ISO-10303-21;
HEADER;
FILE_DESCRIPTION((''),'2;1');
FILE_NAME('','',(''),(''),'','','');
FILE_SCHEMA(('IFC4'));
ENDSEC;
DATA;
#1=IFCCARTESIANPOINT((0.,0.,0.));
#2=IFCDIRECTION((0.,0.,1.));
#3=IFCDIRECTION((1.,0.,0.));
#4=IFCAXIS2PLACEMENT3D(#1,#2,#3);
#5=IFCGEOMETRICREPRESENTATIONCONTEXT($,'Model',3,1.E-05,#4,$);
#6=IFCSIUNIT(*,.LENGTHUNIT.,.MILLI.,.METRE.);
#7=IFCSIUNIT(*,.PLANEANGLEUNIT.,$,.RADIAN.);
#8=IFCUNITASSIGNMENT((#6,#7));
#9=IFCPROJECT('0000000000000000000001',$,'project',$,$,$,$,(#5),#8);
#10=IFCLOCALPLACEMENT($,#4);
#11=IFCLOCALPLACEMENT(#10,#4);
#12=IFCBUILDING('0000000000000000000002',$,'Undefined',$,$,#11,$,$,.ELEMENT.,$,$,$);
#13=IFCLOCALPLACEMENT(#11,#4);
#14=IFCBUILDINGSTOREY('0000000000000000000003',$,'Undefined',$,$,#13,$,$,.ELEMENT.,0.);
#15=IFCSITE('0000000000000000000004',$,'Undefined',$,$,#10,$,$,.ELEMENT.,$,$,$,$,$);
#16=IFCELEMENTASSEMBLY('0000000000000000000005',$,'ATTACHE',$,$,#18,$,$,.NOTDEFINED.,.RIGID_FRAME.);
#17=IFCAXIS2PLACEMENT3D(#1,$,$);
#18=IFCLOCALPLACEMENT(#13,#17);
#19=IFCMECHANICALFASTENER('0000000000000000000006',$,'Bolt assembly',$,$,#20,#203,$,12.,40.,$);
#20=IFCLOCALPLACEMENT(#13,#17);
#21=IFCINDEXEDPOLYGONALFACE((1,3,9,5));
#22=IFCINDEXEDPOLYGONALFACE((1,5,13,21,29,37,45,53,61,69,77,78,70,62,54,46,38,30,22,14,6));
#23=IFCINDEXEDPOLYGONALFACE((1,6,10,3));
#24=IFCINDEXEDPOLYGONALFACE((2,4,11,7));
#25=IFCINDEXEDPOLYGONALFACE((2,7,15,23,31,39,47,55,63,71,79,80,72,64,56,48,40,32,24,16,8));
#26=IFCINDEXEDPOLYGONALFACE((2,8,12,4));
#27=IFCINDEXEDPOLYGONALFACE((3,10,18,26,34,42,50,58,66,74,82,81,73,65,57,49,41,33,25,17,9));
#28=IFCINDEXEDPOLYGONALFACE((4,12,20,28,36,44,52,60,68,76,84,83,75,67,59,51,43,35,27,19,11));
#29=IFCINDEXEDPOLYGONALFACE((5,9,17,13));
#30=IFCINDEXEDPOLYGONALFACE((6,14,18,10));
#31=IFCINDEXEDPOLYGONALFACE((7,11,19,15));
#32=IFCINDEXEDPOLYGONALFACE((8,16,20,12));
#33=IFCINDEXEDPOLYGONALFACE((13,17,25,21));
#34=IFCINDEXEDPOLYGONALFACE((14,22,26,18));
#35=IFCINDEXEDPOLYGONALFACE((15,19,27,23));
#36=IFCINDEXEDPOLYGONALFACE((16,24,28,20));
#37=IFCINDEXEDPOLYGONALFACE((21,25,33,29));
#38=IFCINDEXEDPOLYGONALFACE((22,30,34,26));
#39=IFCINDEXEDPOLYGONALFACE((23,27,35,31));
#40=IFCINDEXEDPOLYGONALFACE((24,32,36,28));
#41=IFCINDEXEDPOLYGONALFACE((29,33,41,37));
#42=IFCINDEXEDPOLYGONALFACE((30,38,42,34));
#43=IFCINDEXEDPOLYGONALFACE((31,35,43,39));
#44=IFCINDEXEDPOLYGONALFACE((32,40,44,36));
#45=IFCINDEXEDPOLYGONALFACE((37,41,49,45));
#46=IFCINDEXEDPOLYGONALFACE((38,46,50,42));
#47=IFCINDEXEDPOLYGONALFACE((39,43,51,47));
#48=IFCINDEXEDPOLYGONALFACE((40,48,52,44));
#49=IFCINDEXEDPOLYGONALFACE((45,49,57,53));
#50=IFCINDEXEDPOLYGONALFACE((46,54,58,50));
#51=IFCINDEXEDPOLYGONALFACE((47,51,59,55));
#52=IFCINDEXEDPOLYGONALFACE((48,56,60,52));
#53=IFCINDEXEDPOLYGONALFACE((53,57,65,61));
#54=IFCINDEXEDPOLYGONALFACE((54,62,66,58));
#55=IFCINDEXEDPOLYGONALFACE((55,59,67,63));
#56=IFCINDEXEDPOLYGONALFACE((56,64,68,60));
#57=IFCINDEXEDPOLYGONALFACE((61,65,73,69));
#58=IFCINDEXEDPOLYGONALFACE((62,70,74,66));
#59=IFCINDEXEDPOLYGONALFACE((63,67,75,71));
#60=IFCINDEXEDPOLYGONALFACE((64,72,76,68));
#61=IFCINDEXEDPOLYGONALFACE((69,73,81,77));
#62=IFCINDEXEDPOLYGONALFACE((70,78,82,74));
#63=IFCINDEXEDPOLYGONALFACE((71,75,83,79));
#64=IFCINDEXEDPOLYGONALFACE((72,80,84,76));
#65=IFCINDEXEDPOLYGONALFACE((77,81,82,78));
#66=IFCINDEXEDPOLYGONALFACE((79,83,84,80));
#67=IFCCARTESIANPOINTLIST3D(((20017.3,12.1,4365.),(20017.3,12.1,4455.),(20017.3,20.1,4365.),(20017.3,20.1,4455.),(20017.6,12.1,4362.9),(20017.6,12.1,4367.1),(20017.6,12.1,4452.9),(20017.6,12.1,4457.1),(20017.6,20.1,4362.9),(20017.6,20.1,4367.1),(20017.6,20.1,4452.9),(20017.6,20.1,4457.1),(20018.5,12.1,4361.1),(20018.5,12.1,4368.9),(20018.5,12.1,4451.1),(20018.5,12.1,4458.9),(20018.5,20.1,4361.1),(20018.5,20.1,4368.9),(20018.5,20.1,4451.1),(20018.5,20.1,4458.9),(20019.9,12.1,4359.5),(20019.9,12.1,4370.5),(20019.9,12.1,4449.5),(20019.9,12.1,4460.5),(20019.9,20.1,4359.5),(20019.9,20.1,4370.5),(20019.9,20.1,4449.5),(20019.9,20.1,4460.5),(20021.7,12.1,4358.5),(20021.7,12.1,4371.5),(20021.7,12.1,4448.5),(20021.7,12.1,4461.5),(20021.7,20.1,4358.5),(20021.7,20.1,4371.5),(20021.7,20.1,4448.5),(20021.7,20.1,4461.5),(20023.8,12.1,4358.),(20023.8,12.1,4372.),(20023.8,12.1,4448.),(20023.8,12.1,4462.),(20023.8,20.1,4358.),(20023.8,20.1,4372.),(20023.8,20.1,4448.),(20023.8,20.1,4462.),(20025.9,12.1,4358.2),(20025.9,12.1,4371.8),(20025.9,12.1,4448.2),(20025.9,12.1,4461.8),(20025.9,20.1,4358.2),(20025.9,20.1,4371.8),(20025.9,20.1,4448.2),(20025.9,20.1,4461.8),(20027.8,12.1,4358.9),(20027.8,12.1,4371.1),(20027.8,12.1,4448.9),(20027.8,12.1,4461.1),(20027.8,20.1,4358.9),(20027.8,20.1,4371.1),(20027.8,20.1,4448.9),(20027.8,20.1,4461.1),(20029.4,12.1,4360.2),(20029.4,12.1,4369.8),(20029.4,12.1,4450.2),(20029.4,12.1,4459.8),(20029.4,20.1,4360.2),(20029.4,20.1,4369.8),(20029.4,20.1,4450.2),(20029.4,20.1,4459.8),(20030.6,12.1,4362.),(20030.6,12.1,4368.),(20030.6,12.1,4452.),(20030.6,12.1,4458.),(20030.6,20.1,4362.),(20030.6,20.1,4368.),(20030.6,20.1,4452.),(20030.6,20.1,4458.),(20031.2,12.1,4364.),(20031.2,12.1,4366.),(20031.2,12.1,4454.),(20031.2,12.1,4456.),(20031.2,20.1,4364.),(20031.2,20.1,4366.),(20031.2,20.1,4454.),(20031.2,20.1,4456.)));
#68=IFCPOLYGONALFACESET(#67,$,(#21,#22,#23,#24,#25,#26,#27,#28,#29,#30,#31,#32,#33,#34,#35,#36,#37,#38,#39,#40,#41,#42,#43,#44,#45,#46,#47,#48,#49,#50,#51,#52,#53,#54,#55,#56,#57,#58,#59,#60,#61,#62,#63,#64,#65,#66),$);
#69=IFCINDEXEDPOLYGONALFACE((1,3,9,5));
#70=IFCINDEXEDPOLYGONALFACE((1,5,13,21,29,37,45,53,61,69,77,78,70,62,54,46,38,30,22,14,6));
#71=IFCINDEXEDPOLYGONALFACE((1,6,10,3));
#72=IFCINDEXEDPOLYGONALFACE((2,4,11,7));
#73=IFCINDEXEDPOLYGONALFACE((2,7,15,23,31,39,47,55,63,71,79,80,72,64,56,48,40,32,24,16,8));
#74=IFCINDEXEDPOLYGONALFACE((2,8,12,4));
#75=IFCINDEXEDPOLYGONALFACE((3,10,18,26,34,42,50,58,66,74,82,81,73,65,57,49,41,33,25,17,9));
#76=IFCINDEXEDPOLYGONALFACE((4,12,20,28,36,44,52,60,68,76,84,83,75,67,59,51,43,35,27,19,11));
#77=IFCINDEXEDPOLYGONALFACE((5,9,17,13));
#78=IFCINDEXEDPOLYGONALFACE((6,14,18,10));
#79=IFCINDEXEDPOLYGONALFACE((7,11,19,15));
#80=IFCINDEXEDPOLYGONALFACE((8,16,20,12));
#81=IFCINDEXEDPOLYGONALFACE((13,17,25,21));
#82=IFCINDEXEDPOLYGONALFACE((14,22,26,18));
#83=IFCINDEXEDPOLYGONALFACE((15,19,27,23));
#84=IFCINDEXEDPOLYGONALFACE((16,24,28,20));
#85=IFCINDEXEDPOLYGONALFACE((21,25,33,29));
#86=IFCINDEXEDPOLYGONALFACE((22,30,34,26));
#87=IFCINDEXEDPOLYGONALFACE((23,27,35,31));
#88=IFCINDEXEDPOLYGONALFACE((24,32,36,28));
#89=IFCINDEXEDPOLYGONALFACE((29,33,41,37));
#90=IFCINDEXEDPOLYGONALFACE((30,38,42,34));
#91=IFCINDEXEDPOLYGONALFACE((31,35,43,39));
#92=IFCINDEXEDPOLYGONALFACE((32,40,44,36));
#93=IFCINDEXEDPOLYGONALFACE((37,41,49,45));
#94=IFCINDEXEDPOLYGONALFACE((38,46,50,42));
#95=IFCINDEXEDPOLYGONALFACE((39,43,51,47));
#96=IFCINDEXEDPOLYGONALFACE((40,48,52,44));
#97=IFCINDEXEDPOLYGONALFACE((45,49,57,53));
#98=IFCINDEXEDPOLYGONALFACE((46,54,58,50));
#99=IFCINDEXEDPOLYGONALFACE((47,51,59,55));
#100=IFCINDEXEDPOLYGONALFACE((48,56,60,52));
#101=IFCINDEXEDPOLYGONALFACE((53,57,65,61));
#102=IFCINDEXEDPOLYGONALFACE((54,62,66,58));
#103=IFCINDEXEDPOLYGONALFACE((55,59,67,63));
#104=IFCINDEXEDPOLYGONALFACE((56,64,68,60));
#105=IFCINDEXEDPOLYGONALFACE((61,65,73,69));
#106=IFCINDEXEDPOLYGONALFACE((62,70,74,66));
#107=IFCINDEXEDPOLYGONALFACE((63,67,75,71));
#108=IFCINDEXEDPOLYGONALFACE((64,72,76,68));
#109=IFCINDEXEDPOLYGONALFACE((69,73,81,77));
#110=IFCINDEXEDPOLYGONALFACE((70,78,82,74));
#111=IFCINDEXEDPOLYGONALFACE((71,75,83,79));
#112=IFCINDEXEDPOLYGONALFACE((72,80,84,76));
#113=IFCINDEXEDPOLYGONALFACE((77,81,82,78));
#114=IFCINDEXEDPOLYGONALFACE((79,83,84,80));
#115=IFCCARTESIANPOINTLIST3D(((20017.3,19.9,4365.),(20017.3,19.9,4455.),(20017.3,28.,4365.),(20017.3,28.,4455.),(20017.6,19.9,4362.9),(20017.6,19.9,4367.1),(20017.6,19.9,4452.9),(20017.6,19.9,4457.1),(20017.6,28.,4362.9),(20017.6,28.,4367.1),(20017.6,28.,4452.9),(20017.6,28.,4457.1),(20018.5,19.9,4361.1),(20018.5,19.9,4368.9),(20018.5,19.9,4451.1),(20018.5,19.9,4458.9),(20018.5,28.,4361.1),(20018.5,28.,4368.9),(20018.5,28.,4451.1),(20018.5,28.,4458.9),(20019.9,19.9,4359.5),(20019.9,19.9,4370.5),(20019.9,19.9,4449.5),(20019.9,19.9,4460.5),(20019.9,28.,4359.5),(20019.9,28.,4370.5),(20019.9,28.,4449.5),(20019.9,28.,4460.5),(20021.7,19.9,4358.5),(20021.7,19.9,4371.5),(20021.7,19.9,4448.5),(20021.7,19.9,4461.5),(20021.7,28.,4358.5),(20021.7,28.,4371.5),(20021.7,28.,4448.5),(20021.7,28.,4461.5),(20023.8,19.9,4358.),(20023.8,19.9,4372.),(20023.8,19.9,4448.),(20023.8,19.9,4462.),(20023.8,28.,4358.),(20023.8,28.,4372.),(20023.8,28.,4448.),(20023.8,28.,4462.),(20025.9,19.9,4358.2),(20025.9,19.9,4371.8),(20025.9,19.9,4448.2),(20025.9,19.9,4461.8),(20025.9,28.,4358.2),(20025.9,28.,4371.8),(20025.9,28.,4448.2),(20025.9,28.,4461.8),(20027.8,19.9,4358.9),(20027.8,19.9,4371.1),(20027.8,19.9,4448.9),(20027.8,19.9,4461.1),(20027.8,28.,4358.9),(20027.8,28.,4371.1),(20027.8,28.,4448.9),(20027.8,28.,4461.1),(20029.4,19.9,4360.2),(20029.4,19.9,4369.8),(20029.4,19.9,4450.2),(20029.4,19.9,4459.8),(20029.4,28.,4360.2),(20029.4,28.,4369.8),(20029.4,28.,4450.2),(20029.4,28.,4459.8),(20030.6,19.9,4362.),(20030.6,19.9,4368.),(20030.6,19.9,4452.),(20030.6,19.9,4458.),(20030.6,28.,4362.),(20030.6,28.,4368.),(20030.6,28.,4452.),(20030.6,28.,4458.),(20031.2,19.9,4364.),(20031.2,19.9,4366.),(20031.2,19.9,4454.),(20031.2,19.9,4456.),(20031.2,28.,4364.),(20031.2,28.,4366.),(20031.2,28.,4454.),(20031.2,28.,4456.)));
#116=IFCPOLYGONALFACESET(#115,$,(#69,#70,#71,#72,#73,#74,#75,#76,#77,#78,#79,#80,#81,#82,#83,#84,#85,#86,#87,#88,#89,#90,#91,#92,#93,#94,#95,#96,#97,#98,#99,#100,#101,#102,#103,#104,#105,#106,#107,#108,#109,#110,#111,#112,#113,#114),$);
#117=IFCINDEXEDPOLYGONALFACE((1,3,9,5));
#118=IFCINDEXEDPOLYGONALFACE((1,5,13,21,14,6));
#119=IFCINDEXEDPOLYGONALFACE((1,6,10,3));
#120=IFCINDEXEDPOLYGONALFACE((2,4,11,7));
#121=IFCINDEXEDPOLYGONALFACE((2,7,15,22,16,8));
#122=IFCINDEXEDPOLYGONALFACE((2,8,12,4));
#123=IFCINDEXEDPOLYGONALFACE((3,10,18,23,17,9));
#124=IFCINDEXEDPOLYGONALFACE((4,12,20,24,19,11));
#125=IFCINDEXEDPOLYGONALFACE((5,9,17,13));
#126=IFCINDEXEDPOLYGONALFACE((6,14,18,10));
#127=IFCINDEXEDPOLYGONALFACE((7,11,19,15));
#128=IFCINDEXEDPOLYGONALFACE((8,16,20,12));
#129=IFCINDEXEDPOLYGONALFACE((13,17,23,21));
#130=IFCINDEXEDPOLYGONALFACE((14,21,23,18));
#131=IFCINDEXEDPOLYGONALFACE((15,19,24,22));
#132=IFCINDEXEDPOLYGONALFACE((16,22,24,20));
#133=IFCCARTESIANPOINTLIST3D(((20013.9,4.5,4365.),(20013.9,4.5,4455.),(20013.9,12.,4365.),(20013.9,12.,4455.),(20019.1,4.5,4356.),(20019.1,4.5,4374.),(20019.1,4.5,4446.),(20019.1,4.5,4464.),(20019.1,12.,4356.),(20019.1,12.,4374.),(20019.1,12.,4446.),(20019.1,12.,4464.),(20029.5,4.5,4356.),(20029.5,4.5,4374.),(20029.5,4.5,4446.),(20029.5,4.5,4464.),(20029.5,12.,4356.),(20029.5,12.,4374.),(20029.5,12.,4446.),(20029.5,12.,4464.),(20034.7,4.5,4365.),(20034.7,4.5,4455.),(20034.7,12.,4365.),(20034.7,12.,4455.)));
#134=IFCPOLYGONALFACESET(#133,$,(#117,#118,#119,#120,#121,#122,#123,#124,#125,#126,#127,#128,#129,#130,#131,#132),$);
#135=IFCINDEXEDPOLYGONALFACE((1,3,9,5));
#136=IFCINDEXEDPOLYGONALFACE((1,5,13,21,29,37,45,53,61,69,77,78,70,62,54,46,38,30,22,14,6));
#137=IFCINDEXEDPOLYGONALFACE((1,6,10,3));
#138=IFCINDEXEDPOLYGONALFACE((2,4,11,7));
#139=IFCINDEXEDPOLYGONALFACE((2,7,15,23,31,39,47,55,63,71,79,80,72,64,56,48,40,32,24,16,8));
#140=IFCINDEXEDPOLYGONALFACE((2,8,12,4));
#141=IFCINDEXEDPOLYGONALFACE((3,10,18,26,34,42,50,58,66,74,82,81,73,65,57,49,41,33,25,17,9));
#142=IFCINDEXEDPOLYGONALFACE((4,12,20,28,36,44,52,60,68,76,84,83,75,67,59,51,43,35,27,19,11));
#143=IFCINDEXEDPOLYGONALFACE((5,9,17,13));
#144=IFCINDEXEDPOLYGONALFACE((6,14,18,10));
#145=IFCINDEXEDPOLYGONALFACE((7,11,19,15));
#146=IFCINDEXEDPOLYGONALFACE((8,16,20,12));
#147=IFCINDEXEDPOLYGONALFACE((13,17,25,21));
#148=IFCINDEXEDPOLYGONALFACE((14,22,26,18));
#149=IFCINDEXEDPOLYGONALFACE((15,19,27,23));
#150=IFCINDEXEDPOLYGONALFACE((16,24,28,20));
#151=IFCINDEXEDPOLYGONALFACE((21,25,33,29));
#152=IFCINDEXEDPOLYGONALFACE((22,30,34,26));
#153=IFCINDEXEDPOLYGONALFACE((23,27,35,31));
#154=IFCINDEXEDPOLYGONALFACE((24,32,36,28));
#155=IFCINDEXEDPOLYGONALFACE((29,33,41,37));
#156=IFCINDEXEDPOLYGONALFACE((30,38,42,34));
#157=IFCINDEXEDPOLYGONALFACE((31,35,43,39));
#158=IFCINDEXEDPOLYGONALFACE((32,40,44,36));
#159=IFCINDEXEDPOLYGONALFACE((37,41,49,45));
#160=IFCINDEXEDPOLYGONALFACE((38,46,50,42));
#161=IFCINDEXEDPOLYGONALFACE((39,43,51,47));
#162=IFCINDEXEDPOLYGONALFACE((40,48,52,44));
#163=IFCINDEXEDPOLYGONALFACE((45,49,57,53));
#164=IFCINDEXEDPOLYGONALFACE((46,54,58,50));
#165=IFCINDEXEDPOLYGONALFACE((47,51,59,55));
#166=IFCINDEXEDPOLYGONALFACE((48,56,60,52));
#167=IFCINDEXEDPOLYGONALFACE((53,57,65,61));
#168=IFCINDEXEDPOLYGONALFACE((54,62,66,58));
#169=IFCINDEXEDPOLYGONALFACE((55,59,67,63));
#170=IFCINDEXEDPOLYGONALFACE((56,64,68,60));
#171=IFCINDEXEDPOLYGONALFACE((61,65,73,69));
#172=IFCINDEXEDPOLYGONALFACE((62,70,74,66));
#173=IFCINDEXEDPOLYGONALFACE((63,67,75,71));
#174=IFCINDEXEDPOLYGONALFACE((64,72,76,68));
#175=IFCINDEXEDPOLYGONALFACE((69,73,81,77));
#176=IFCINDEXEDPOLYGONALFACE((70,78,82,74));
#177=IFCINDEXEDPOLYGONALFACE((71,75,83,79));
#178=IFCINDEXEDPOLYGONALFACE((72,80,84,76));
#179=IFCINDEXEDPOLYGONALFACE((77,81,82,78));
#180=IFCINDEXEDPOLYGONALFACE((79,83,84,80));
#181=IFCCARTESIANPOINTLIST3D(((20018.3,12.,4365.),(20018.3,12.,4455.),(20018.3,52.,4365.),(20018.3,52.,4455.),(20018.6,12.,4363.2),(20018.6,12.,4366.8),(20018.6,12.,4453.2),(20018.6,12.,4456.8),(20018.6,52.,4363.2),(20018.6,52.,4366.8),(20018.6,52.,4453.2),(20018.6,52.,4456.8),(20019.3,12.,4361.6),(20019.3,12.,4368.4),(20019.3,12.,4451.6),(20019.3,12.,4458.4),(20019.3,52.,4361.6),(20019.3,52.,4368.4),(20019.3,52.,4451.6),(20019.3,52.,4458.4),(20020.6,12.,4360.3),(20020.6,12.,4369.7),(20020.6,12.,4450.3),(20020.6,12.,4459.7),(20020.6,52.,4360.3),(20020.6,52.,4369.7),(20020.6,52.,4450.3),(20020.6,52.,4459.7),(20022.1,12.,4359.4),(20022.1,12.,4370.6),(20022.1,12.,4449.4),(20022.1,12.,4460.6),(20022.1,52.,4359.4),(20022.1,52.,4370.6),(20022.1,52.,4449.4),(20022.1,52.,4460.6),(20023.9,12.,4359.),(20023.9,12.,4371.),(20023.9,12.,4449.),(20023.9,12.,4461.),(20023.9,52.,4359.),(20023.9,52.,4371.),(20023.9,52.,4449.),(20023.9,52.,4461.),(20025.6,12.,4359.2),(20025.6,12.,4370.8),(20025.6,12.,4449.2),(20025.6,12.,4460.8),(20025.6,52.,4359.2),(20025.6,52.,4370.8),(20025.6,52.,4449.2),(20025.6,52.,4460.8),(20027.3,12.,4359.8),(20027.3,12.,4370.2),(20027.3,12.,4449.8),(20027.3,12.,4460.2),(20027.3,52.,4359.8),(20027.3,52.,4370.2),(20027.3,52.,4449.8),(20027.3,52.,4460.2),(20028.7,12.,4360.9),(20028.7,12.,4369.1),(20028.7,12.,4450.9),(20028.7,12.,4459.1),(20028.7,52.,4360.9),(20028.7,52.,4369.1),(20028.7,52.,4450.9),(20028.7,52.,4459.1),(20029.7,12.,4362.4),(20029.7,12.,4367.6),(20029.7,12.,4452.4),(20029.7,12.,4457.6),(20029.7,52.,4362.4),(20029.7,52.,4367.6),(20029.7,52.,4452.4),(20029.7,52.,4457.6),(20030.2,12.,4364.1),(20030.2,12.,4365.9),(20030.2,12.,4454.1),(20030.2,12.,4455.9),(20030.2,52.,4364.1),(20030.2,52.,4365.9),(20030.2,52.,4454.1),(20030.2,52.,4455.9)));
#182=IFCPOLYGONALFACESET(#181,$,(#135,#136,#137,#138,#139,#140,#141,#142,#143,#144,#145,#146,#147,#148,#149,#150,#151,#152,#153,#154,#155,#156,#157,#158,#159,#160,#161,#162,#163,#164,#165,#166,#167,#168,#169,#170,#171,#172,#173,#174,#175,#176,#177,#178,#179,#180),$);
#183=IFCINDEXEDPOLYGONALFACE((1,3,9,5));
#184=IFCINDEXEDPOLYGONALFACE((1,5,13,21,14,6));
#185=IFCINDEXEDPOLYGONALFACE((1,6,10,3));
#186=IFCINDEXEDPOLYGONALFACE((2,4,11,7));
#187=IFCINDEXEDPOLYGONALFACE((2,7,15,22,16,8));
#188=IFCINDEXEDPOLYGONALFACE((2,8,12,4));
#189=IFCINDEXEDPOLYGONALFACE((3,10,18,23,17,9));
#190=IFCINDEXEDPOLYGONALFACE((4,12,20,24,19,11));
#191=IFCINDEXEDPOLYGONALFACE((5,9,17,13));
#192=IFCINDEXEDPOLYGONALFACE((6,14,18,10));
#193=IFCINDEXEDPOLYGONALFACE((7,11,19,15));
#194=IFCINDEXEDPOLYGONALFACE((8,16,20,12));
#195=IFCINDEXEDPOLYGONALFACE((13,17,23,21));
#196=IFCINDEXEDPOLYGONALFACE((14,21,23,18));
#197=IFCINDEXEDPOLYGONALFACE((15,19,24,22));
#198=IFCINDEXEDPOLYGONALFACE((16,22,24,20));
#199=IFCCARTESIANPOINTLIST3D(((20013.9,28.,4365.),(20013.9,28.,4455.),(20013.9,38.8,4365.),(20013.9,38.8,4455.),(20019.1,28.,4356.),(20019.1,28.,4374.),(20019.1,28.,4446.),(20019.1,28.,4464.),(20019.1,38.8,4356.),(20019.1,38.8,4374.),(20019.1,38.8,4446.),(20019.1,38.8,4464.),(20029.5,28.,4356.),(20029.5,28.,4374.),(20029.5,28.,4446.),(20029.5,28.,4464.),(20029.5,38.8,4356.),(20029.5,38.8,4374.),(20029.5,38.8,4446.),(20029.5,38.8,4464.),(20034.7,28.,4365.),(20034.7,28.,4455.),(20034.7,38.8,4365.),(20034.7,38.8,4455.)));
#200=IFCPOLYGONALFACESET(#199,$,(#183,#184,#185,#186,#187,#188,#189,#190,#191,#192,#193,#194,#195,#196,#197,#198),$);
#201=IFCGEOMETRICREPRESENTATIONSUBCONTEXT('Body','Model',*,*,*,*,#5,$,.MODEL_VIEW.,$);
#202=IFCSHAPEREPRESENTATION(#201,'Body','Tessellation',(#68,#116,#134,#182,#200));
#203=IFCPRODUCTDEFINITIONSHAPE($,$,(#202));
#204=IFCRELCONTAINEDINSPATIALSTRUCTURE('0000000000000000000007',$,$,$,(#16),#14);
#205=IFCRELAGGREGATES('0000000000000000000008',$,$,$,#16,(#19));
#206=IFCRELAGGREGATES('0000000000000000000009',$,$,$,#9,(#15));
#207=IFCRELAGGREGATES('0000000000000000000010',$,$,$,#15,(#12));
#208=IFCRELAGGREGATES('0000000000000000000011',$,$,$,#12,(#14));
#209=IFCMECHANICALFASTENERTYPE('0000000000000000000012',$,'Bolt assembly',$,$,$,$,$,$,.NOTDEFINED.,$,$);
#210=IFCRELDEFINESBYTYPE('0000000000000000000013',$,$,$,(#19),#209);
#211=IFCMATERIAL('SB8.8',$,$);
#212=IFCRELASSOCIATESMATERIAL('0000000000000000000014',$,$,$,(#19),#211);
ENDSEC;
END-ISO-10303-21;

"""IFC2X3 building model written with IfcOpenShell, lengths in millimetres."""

from ifc_helpers import new_model, si_unit, frame, origin_with_axes, origin_2d_with_axis, place, context, subcontext, project, spatial, polyline, circle, outline, extrude, source, transform, mapped, material, type_object, element, aggregate, save


model = new_model("IFC2X3")

# Units and contexts
model_context = context("Model", 3, precision=1e-05, world=origin_with_axes())
body_context = subcontext(model_context, "Body", "Model", "MODEL_VIEW")
ifc_project = project(units=[si_unit("LENGTHUNIT", "METRE", prefix="MILLI"), si_unit("PLANEANGLEUNIT", "RADIAN")], contexts=[model_context])

# Site, building, storey
site_placement = place(None, origin_with_axes())
site = spatial("IfcSite", under=ifc_project, at=site_placement, Name="Undefined", CompositionType="ELEMENT")
building_placement = place(site_placement, origin_with_axes())
building = spatial("IfcBuilding", under=site, at=building_placement, Name="Undefined", CompositionType="ELEMENT")
storey_placement = place(building_placement, origin_with_axes())
storey = spatial("IfcBuildingStorey", under=building, at=storey_placement, Name="Undefined", CompositionType="ELEMENT", Elevation=0.0)

# Element assembly
assembly_1_placement = place(storey_placement, origin_with_axes())
assembly_1 = element("IfcElementAssembly", 1, at=assembly_1_placement, inside=storey, Name="ATTACHE", AssemblyPlace="NOTDEFINED", PredefinedType="RIGID_FRAME")

# Shared definitions
ifc_material_1 = material(Name="SB8.8")
mechanical_fastener_type = type_object("IfcMechanicalFastenerType", Name="Bolt assembly")

# Mechanical fastener
shared_shape_1 = source(origin_with_axes(), body_context, "Body", "SweptSolid", [
    extrude(circle(Radius=7.0, at=origin_2d_with_axis()), frame((0.0, -7.9, 0.0), z_axis=(0.0, 1.0, 0.0), x_axis=(1.0, 0.0, 0.0)), (0.0, 0.0, 1.0), 8.0),
    extrude(circle(Radius=7.0, at=origin_2d_with_axis()), frame((0.0, -0.1, 0.0), z_axis=(0.0, 1.0, 0.0), x_axis=(1.0, 0.0, 0.0)), (0.0, 0.0, 1.0), 8.1),
    extrude(outline(polyline([(10.4, 0.0), (5.2, 9.0), (-5.2, 9.0), (-10.4, 0.0), (-5.2, -9.0), (5.2, -9.0), (10.4, 0.0)])), frame((0.0, -15.5, 0.0), z_axis=(0.0, 1.0, 0.0), x_axis=(1.0, 0.0, 0.0)), (0.0, 0.0, 1.0), 7.5),
    extrude(circle(Radius=6.0, at=origin_2d_with_axis()), frame((0.0, -8.0, 0.0), z_axis=(0.0, 1.0, 0.0), x_axis=(1.0, 0.0, 0.0)), (0.0, 0.0, 1.0), 40.0),
    extrude(outline(polyline([(10.4, 0.0), (5.2, 9.0), (-5.2, 9.0), (-10.4, 0.0), (-5.2, -9.0), (5.2, -9.0), (10.4, 0.0)])), frame((0.0, 8.0, 0.0), z_axis=(0.0, 1.0, 0.0), x_axis=(1.0, 0.0, 0.0)), (0.0, 0.0, 1.0), 10.8),
])
mechanical_fastener_1_placement = place(assembly_1_placement, frame((20024.3, 20.0, 4410.0), z_axis=(0.0, 0.0, -1.0), x_axis=(-1.0, -0.000104, 0.0)))
mechanical_fastener_1 = element("IfcMechanicalFastener", 2, at=mechanical_fastener_1_placement, type_object=mechanical_fastener_type, material=ifc_material_1, Name="Bolt assembly", NominalDiameter=12.0, NominalLength=40.0, context=body_context, shape_type="MappedRepresentation", body=[
    mapped(shared_shape_1, transform((0.0, 0.0, 45.0))),
    mapped(shared_shape_1, transform((0.0, 0.0, -45.0))),
])
aggregate(assembly_1, [mechanical_fastener_1])

save(model, "model.ifc")
